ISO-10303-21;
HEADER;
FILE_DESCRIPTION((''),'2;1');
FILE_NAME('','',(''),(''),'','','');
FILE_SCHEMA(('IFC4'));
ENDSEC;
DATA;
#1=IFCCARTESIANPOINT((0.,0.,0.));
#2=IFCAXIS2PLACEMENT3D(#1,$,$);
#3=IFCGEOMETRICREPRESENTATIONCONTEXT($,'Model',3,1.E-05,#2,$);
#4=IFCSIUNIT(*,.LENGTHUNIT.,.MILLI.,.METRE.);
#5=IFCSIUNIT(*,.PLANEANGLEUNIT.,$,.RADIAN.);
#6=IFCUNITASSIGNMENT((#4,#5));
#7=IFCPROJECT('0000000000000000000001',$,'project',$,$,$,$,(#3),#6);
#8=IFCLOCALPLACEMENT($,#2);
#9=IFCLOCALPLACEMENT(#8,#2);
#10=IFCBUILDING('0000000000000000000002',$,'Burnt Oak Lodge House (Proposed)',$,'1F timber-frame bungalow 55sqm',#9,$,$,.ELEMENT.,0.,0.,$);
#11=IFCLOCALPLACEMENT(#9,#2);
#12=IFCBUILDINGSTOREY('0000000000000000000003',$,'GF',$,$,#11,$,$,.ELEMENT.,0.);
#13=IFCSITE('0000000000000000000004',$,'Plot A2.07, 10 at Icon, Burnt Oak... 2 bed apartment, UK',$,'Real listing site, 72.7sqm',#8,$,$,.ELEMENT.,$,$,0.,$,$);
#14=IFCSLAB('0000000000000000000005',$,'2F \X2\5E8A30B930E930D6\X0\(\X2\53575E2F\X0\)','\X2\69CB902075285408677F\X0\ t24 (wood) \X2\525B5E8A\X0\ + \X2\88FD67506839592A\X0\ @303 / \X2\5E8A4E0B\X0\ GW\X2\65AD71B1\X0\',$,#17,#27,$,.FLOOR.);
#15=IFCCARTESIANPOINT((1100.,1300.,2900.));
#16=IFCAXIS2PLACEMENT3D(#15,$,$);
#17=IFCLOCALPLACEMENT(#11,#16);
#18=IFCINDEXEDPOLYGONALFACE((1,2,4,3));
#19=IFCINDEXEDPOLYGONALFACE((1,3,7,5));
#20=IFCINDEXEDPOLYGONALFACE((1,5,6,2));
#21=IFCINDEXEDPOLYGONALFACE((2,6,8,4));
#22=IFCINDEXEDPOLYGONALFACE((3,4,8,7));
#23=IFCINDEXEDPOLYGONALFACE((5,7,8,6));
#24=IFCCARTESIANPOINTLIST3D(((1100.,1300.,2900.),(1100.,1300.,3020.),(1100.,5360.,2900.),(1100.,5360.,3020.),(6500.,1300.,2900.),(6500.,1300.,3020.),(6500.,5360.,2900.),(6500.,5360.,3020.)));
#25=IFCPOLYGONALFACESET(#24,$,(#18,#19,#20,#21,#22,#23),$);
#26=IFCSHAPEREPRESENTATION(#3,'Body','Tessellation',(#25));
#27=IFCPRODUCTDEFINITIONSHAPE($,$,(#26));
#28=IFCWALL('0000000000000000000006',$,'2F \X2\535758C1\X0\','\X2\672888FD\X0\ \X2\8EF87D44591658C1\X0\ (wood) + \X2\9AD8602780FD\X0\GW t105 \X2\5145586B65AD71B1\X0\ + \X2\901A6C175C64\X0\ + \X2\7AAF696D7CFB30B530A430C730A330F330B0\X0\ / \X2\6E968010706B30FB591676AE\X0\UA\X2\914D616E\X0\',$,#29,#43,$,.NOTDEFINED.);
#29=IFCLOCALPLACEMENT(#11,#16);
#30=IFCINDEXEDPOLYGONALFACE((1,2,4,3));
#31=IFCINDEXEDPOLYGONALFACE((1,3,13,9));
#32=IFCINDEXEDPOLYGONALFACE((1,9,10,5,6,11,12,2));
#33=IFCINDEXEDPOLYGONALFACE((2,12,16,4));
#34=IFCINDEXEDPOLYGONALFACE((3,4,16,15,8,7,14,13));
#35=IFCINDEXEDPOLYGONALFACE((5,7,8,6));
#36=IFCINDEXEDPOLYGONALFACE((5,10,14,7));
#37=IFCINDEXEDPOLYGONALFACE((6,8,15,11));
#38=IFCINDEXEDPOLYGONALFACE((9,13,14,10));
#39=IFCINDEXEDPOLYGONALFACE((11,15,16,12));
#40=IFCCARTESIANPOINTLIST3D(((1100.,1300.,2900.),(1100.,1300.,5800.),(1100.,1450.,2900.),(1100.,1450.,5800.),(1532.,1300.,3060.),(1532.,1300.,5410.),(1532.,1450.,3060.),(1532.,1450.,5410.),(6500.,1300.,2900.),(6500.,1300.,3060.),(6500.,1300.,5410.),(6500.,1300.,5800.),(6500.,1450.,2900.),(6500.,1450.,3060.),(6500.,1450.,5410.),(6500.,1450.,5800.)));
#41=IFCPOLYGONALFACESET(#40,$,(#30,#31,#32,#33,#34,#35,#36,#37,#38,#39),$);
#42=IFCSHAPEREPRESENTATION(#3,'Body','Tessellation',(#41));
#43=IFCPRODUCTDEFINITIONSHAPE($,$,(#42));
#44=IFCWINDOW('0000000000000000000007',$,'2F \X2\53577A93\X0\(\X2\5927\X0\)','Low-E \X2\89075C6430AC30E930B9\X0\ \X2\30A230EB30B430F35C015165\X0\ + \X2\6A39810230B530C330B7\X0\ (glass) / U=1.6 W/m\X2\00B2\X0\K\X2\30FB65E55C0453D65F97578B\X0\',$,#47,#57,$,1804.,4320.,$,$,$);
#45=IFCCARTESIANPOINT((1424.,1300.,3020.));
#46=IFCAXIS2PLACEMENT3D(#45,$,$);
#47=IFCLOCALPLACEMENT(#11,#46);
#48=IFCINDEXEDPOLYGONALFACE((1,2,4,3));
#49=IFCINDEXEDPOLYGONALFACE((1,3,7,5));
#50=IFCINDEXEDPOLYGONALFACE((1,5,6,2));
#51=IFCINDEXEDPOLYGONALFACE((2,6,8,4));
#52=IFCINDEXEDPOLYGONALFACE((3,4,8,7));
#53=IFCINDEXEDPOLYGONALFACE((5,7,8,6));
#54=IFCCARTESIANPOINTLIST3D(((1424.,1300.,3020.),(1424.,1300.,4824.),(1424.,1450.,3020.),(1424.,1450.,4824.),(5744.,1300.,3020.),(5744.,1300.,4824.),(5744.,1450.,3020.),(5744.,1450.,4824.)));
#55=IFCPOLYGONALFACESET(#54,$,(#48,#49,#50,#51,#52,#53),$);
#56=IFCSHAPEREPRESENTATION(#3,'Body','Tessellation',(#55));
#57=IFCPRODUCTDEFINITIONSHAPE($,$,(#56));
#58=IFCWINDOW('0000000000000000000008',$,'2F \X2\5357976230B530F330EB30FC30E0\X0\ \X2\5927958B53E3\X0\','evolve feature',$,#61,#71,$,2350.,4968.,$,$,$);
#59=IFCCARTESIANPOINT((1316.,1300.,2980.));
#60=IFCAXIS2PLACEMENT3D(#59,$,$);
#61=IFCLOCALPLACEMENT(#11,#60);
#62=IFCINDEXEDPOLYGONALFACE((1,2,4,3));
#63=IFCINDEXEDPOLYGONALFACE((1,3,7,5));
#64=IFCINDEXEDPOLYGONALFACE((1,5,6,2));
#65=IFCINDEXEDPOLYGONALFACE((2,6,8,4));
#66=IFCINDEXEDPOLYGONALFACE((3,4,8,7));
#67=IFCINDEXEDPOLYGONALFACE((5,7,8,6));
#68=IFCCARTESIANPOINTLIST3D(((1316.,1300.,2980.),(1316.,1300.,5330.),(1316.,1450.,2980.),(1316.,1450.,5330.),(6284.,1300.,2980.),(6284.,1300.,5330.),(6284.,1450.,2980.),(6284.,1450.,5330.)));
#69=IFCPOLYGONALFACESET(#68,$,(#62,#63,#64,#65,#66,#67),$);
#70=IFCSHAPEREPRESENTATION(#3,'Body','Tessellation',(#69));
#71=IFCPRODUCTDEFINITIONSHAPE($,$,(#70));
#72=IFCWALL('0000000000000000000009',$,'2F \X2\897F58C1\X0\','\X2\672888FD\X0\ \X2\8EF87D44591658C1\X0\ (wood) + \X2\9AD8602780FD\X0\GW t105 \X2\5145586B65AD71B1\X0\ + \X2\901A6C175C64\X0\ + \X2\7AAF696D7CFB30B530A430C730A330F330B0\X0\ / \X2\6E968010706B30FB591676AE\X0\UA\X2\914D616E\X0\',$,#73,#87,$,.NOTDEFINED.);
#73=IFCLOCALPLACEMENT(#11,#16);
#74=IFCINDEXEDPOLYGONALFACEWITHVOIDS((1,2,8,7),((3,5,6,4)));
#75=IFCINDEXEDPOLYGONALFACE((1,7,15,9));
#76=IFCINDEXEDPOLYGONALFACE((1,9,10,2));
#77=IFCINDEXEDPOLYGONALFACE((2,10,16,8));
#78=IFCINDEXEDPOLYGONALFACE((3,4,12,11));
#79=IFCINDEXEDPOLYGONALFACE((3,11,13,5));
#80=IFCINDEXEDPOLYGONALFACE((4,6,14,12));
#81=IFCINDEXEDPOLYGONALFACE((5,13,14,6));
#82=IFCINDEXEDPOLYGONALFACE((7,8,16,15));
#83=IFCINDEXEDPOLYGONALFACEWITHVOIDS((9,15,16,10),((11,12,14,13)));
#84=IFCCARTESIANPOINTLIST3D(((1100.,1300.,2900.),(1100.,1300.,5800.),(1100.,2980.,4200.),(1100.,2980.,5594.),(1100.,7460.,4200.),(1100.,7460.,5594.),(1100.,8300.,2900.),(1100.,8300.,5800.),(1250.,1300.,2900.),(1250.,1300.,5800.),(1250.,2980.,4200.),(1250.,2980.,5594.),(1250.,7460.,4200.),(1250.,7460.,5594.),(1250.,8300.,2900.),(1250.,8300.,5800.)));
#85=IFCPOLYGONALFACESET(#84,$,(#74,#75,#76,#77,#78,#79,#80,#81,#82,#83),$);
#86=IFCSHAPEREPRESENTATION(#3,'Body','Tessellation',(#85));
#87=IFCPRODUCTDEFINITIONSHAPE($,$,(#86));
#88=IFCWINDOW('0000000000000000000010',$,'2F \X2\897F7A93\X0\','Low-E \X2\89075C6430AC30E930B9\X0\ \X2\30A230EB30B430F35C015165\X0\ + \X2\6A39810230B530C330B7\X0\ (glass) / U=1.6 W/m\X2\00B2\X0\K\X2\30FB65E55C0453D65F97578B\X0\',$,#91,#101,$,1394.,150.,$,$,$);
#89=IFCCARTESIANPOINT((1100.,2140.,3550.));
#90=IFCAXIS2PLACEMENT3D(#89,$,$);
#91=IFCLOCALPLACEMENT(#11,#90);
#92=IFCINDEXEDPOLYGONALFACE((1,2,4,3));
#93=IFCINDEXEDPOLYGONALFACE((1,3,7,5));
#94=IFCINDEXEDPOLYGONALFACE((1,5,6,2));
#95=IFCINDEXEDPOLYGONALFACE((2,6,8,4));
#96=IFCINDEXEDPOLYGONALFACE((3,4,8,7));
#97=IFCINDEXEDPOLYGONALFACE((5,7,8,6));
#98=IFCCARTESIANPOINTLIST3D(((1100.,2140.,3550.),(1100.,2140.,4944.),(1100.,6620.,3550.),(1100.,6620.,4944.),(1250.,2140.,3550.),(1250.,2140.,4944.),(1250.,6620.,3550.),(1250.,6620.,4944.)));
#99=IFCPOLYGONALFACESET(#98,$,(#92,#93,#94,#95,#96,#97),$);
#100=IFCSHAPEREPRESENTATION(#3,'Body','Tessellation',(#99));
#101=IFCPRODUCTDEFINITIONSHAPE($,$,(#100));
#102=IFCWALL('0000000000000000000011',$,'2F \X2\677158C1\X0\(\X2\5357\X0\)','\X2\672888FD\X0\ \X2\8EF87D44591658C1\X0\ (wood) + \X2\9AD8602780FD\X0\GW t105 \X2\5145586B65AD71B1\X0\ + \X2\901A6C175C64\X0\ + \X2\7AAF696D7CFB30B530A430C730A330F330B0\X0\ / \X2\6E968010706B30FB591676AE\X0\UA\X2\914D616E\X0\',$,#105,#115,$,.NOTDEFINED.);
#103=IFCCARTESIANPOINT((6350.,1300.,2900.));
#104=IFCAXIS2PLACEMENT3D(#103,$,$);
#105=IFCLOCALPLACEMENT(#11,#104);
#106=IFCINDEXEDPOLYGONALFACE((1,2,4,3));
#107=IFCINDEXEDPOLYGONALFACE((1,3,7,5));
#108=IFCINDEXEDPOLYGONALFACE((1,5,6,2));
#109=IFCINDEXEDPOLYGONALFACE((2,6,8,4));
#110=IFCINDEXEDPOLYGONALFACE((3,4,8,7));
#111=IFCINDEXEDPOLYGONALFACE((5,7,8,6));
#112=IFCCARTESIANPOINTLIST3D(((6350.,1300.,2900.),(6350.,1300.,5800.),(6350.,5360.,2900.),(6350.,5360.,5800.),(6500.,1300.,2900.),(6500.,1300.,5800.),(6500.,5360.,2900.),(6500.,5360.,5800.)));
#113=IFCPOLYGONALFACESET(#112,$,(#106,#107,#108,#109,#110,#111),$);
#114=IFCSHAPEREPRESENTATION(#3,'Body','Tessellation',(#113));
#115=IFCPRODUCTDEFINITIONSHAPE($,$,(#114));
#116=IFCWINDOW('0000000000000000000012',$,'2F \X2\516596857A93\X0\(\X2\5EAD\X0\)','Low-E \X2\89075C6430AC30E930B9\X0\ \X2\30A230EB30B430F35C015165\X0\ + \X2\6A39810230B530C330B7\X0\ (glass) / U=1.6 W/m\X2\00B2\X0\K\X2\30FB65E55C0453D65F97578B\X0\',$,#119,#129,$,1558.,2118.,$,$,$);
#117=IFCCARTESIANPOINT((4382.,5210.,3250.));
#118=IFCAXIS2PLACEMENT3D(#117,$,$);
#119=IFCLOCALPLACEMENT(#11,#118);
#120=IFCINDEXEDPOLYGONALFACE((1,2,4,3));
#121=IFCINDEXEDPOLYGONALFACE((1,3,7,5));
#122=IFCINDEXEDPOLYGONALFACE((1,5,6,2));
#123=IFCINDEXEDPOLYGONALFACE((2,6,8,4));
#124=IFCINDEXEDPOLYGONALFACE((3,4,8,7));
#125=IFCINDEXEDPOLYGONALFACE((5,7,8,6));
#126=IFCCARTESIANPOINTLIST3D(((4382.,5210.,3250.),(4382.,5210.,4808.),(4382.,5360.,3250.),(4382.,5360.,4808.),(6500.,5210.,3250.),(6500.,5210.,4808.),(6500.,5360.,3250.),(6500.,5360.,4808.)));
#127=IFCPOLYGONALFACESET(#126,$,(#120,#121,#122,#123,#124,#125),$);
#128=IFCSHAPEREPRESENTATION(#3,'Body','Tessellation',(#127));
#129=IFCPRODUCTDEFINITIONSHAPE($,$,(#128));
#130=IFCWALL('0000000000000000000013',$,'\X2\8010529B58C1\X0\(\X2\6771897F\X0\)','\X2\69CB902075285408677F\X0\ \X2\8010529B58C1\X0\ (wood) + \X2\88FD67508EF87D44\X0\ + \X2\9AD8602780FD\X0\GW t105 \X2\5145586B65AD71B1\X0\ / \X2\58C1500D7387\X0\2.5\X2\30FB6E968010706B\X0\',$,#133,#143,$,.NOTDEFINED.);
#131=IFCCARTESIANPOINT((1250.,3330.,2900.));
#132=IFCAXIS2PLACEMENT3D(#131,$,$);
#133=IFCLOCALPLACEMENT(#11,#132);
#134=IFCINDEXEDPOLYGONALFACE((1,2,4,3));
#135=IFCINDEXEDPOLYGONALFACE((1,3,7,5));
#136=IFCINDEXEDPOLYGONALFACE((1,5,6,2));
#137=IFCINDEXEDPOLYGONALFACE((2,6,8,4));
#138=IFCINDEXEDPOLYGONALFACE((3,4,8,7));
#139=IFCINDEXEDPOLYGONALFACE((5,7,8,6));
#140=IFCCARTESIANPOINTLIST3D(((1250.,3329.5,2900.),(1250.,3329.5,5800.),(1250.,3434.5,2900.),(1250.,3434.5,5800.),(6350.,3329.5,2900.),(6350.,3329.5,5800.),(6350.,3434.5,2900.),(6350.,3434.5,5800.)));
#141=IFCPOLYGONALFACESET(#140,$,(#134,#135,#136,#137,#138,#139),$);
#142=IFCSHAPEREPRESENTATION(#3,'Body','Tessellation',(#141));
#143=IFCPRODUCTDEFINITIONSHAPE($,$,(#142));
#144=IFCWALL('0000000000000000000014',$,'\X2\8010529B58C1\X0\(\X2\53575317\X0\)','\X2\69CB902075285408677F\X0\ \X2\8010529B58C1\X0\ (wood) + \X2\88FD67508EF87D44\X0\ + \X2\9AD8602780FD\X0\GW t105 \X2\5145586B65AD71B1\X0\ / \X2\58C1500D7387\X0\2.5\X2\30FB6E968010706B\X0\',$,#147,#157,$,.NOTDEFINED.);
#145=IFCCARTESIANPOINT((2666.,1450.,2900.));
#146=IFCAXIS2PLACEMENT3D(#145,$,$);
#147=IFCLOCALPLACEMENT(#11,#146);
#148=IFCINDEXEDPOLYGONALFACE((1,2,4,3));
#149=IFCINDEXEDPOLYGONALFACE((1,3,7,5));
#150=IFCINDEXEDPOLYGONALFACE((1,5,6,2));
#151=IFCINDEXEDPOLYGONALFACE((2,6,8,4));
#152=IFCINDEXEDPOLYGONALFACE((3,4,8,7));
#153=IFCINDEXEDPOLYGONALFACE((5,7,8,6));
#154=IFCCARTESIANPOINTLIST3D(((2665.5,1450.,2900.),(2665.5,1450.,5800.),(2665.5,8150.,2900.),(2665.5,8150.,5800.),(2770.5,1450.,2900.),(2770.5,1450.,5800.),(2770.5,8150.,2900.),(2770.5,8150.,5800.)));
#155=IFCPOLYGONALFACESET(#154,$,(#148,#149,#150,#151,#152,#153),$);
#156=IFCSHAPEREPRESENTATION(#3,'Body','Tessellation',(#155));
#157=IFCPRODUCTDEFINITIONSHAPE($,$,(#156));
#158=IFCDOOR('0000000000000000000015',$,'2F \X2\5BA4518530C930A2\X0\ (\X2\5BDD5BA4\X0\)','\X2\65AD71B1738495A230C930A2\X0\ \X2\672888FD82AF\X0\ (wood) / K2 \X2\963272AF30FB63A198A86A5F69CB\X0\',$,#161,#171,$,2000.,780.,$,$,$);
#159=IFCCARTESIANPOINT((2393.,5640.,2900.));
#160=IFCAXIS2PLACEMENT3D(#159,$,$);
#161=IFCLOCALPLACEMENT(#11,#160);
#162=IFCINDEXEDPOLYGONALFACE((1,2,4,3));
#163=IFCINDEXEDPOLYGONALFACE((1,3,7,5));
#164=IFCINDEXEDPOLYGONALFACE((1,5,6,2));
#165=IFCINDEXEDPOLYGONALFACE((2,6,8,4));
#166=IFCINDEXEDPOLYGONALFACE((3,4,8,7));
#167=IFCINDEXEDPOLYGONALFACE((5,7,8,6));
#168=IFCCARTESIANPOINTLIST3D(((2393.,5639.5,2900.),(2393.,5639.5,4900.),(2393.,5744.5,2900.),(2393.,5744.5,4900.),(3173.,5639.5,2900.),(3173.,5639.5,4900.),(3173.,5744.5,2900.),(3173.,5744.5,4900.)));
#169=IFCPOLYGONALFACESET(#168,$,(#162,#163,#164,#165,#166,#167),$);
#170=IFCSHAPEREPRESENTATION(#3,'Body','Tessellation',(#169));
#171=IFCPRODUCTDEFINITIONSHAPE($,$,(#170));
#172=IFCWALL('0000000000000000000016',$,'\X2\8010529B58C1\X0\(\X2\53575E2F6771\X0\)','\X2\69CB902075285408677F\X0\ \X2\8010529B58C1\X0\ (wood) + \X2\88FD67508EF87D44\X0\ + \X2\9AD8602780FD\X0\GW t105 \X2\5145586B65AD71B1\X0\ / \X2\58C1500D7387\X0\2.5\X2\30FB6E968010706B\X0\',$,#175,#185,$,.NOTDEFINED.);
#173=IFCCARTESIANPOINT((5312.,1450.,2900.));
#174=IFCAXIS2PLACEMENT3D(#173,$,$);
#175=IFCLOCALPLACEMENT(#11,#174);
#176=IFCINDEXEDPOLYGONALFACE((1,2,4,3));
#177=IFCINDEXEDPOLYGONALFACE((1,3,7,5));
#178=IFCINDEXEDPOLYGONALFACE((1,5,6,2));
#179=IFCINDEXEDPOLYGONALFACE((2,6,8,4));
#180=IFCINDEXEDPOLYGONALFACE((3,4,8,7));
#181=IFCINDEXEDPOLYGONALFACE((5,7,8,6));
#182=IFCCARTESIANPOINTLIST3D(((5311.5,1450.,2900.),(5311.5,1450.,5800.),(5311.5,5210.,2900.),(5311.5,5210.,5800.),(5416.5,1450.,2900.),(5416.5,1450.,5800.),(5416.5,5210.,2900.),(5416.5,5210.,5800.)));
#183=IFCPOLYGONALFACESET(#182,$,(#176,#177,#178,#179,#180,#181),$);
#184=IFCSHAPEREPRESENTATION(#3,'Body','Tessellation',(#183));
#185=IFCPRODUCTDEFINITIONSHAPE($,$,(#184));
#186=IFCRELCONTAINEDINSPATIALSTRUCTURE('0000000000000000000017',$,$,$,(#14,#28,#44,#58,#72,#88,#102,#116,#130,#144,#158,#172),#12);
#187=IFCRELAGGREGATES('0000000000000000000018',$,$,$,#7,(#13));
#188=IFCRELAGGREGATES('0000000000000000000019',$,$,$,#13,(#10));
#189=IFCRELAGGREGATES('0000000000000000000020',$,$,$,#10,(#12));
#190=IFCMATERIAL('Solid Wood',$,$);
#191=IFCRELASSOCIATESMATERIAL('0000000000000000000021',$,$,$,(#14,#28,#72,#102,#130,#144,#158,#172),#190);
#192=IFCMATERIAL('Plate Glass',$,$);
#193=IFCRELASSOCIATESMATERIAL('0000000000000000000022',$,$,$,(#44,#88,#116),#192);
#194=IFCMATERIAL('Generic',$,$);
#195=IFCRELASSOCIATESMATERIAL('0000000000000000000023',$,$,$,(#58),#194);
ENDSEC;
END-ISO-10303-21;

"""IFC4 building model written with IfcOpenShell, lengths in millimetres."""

from ifc_helpers import new_model, si_unit, frame, frame_2d, origin, place, context, project, spatial, rectangle, extrude, material, element, fill, save


model = new_model("IFC4")

# Units and contexts
model_context = context("Model", 3, precision=1e-05, world=origin())
ifc_project = project(units=[si_unit("LENGTHUNIT", "METRE", prefix="MILLI"), si_unit("PLANEANGLEUNIT", "RADIAN")], contexts=[model_context])

# Site, building, storey
site_placement = place(None, origin())
site = spatial("IfcSite", under=ifc_project, at=site_placement, Name="Plot A2.07, 10 at Icon, Burnt Oak... 2 bed apartment, UK", ObjectType="Real listing site, 72.7sqm", CompositionType="ELEMENT", RefElevation=0.0)
building_placement = place(site_placement, origin())
building = spatial("IfcBuilding", under=site, at=building_placement, Name="Burnt Oak Lodge House (Proposed)", ObjectType="1F timber-frame bungalow 55sqm", CompositionType="ELEMENT", ElevationOfRefHeight=0.0, ElevationOfTerrain=0.0)
storey_placement = place(building_placement, origin())
storey = spatial("IfcBuildingStorey", under=building, at=storey_placement, Name="GF", CompositionType="ELEMENT", Elevation=0.0)

# Slab
ifc_material_1 = material(Name="Solid Wood")
slab_placement = place(storey_placement, frame((1100.0, 1300.0, 2900.0)))
element("IfcSlab", 1, at=slab_placement, inside=storey, material=ifc_material_1, Name="2F 床スラブ(南帯)", Description="構造用合板 t24 (wood) 剛床 + 製材根太 @303 / 床下 GW断熱", PredefinedType="FLOOR", context=model_context, shape_type="SweptSolid", body=[
    extrude(rectangle(XDim=5400.0, YDim=4060.0, at=frame_2d((2700.0, 2030.0))), frame((1100.0, 1300.0, 2900.0)), (0.0, 0.0, 1.0), 120.0),
])

# Wall, openings, windows
wall_1_placement = place(storey_placement, frame((1100.0, 1300.0, 2900.0)))
wall_1 = element("IfcWall", 2, at=wall_1_placement, inside=storey, material=ifc_material_1, Name="2F 南壁", Description="木製 軸組外壁 (wood) + 高性能GW t105 充填断熱 + 通気層 + 窯業系サイディング / 準耐火・外皮UA配慮", PredefinedType="NOTDEFINED", context=model_context, shape_type="SweptSolid", body=[
    extrude(rectangle(XDim=5400.0, YDim=150.0, at=frame_2d((2700.0, 75.0))), frame((1100.0, 1300.0, 2900.0)), (0.0, 0.0, 1.0), 2900.0),
])
opening_1_placement = place(storey_placement, frame((1424.0, 1300.0, 3020.0)))
opening_1 = element("IfcOpeningElement", 3, at=opening_1_placement, cuts=wall_1, PredefinedType="NOTDEFINED", context=model_context, shape_type="SweptSolid", body=[
    extrude(rectangle(XDim=4320.0, YDim=150.0, at=frame_2d((2160.0, 75.0))), frame((1424.0, 1300.0, 3020.0)), (0.0, 0.0, 1.0), 1804.0),
])
opening_2_placement = place(storey_placement, frame((1316.0, 1300.0, 2980.0)))
opening_2 = element("IfcOpeningElement", 4, at=opening_2_placement, cuts=wall_1, PredefinedType="NOTDEFINED", context=model_context, shape_type="SweptSolid", body=[
    extrude(rectangle(XDim=4968.0, YDim=150.0, at=frame_2d((2484.0, 75.0))), frame((1316.0, 1300.0, 2980.0)), (0.0, 0.0, 1.0), 2350.0),
])
ifc_material_2 = material(Name="Plate Glass")
window_1_placement = place(storey_placement, frame((1424.0, 1300.0, 3020.0)))
window_1 = element("IfcWindow", 5, at=window_1_placement, inside=storey, material=ifc_material_2, Name="2F 南窓(大)", Description="Low-E 複層ガラス アルゴン封入 + 樹脂サッシ (glass) / U=1.6 W/m²K・日射取得型", OverallHeight=1804.0, OverallWidth=4320.0, context=model_context, shape_type="SweptSolid", body=[
    extrude(rectangle(XDim=4320.0, YDim=150.0, at=frame_2d((2160.0, 75.0))), frame((1424.0, 1300.0, 3020.0)), (0.0, 0.0, 1.0), 1804.0),
])
fill(opening_1, window_1)
ifc_material_3 = material(Name="Generic")
window_2_placement = place(storey_placement, frame((1316.0, 1300.0, 2980.0)))
window_2 = element("IfcWindow", 6, at=window_2_placement, inside=storey, material=ifc_material_3, Name="2F 南面サンルーム 大開口", Description="evolve feature", OverallHeight=2350.0, OverallWidth=4968.0, context=model_context, shape_type="SweptSolid", body=[
    extrude(rectangle(XDim=4968.0, YDim=150.0, at=frame_2d((2484.0, 75.0))), frame((1316.0, 1300.0, 2980.0)), (0.0, 0.0, 1.0), 2350.0),
])
fill(opening_2, window_2)

# Walls, openings, windows
wall_2_placement = place(storey_placement, frame((1100.0, 1300.0, 2900.0)))
wall_2 = element("IfcWall", 7, at=wall_2_placement, inside=storey, material=ifc_material_1, Name="2F 西壁", Description="木製 軸組外壁 (wood) + 高性能GW t105 充填断熱 + 通気層 + 窯業系サイディング / 準耐火・外皮UA配慮", PredefinedType="NOTDEFINED", context=model_context, shape_type="SweptSolid", body=[
    extrude(rectangle(XDim=150.0, YDim=7000.0, at=frame_2d((75.0, 3500.0))), frame((1100.0, 1300.0, 2900.0)), (0.0, 0.0, 1.0), 2900.0),
])
opening_3_placement = place(storey_placement, frame((1100.0, 2140.0, 3550.0)))
opening_3 = element("IfcOpeningElement", 8, at=opening_3_placement, cuts=wall_2, PredefinedType="NOTDEFINED", context=model_context, shape_type="SweptSolid", body=[
    extrude(rectangle(XDim=150.0, YDim=4480.0, at=frame_2d((75.0, 2240.0))), frame((1100.0, 2140.0, 3550.0)), (0.0, 0.0, 1.0), 1394.0),
])
window_3_placement = place(storey_placement, frame((1100.0, 2140.0, 3550.0)))
window_3 = element("IfcWindow", 9, at=window_3_placement, inside=storey, material=ifc_material_2, Name="2F 西窓", Description="Low-E 複層ガラス アルゴン封入 + 樹脂サッシ (glass) / U=1.6 W/m²K・日射取得型", OverallHeight=1394.0, OverallWidth=150.0, context=model_context, shape_type="SweptSolid", body=[
    extrude(rectangle(XDim=150.0, YDim=4480.0, at=frame_2d((75.0, 2240.0))), frame((1100.0, 2140.0, 3550.0)), (0.0, 0.0, 1.0), 1394.0),
])
fill(opening_3, window_3)
wall_3_placement = place(storey_placement, frame((6350.0, 1300.0, 2900.0)))
wall_3 = element("IfcWall", 10, at=wall_3_placement, inside=storey, material=ifc_material_1, Name="2F 東壁(南)", Description="木製 軸組外壁 (wood) + 高性能GW t105 充填断熱 + 通気層 + 窯業系サイディング / 準耐火・外皮UA配慮", PredefinedType="NOTDEFINED", context=model_context, shape_type="SweptSolid", body=[
    extrude(rectangle(XDim=150.0, YDim=4060.0, at=frame_2d((75.0, 2030.0))), frame((6350.0, 1300.0, 2900.0)), (0.0, 0.0, 1.0), 2900.0),
])
opening_4_placement = place(storey_placement, frame((4382.0, 5210.0, 3250.0)))
opening_4 = element("IfcOpeningElement", 11, at=opening_4_placement, cuts=wall_3, PredefinedType="NOTDEFINED", context=model_context, shape_type="SweptSolid", body=[
    extrude(rectangle(XDim=2118.0, YDim=150.0, at=frame_2d((1059.0, 75.0))), frame((4382.0, 5210.0, 3250.0)), (0.0, 0.0, 1.0), 1558.0),
])
window_4_placement = place(storey_placement, frame((4382.0, 5210.0, 3250.0)))
window_4 = element("IfcWindow", 12, at=window_4_placement, inside=storey, material=ifc_material_2, Name="2F 入隅窓(庭)", Description="Low-E 複層ガラス アルゴン封入 + 樹脂サッシ (glass) / U=1.6 W/m²K・日射取得型", OverallHeight=1558.0, OverallWidth=2118.0, context=model_context, shape_type="SweptSolid", body=[
    extrude(rectangle(XDim=2118.0, YDim=150.0, at=frame_2d((1059.0, 75.0))), frame((4382.0, 5210.0, 3250.0)), (0.0, 0.0, 1.0), 1558.0),
])
fill(opening_4, window_4)

# Wall
wall_4_placement = place(storey_placement, frame((1250.0, 3330.0, 2900.0)))
element("IfcWall", 13, at=wall_4_placement, inside=storey, material=ifc_material_1, Name="耐力壁(東西)", Description="構造用合板 耐力壁 (wood) + 製材軸組 + 高性能GW t105 充填断熱 / 壁倍率2.5・準耐火", PredefinedType="NOTDEFINED", context=model_context, shape_type="SweptSolid", body=[
    extrude(rectangle(XDim=5100.0, YDim=105.0, at=frame_2d((2550.0, 52.0))), frame((1250.0, 3330.0, 2900.0)), (0.0, 0.0, 1.0), 2900.0),
])

# Wall, opening, door
wall_5_placement = place(storey_placement, frame((2666.0, 1450.0, 2900.0)))
wall_5 = element("IfcWall", 14, at=wall_5_placement, inside=storey, material=ifc_material_1, Name="耐力壁(南北)", Description="構造用合板 耐力壁 (wood) + 製材軸組 + 高性能GW t105 充填断熱 / 壁倍率2.5・準耐火", PredefinedType="NOTDEFINED", context=model_context, shape_type="SweptSolid", body=[
    extrude(rectangle(XDim=105.0, YDim=6700.0, at=frame_2d((52.0, 3350.0))), frame((2666.0, 1450.0, 2900.0)), (0.0, 0.0, 1.0), 2900.0),
])
opening_5_placement = place(storey_placement, frame((2393.0, 5640.0, 2900.0)))
opening_5 = element("IfcOpeningElement", 15, at=opening_5_placement, cuts=wall_5, PredefinedType="NOTDEFINED", context=model_context, shape_type="SweptSolid", body=[
    extrude(rectangle(XDim=780.0, YDim=105.0, at=frame_2d((390.0, 52.0))), frame((2393.0, 5640.0, 2900.0)), (0.0, 0.0, 1.0), 2000.0),
])
door_placement = place(storey_placement, frame((2393.0, 5640.0, 2900.0)))
door = element("IfcDoor", 16, at=door_placement, inside=storey, material=ifc_material_1, Name="2F 室内ドア (寝室)", Description="断熱玄関ドア 木製芯 (wood) / K2 防犯・採風機構", OverallHeight=2000.0, OverallWidth=780.0, context=model_context, shape_type="SweptSolid", body=[
    extrude(rectangle(XDim=780.0, YDim=105.0, at=frame_2d((390.0, 52.0))), frame((2393.0, 5640.0, 2900.0)), (0.0, 0.0, 1.0), 2000.0),
])
fill(opening_5, door)

# Wall
wall_6_placement = place(storey_placement, frame((5312.0, 1450.0, 2900.0)))
element("IfcWall", 17, at=wall_6_placement, inside=storey, material=ifc_material_1, Name="耐力壁(南帯東)", Description="構造用合板 耐力壁 (wood) + 製材軸組 + 高性能GW t105 充填断熱 / 壁倍率2.5・準耐火", PredefinedType="NOTDEFINED", context=model_context, shape_type="SweptSolid", body=[
    extrude(rectangle(XDim=105.0, YDim=3760.0, at=frame_2d((52.0, 1880.0))), frame((5312.0, 1450.0, 2900.0)), (0.0, 0.0, 1.0), 2900.0),
])

save(model, "model.ifc")
